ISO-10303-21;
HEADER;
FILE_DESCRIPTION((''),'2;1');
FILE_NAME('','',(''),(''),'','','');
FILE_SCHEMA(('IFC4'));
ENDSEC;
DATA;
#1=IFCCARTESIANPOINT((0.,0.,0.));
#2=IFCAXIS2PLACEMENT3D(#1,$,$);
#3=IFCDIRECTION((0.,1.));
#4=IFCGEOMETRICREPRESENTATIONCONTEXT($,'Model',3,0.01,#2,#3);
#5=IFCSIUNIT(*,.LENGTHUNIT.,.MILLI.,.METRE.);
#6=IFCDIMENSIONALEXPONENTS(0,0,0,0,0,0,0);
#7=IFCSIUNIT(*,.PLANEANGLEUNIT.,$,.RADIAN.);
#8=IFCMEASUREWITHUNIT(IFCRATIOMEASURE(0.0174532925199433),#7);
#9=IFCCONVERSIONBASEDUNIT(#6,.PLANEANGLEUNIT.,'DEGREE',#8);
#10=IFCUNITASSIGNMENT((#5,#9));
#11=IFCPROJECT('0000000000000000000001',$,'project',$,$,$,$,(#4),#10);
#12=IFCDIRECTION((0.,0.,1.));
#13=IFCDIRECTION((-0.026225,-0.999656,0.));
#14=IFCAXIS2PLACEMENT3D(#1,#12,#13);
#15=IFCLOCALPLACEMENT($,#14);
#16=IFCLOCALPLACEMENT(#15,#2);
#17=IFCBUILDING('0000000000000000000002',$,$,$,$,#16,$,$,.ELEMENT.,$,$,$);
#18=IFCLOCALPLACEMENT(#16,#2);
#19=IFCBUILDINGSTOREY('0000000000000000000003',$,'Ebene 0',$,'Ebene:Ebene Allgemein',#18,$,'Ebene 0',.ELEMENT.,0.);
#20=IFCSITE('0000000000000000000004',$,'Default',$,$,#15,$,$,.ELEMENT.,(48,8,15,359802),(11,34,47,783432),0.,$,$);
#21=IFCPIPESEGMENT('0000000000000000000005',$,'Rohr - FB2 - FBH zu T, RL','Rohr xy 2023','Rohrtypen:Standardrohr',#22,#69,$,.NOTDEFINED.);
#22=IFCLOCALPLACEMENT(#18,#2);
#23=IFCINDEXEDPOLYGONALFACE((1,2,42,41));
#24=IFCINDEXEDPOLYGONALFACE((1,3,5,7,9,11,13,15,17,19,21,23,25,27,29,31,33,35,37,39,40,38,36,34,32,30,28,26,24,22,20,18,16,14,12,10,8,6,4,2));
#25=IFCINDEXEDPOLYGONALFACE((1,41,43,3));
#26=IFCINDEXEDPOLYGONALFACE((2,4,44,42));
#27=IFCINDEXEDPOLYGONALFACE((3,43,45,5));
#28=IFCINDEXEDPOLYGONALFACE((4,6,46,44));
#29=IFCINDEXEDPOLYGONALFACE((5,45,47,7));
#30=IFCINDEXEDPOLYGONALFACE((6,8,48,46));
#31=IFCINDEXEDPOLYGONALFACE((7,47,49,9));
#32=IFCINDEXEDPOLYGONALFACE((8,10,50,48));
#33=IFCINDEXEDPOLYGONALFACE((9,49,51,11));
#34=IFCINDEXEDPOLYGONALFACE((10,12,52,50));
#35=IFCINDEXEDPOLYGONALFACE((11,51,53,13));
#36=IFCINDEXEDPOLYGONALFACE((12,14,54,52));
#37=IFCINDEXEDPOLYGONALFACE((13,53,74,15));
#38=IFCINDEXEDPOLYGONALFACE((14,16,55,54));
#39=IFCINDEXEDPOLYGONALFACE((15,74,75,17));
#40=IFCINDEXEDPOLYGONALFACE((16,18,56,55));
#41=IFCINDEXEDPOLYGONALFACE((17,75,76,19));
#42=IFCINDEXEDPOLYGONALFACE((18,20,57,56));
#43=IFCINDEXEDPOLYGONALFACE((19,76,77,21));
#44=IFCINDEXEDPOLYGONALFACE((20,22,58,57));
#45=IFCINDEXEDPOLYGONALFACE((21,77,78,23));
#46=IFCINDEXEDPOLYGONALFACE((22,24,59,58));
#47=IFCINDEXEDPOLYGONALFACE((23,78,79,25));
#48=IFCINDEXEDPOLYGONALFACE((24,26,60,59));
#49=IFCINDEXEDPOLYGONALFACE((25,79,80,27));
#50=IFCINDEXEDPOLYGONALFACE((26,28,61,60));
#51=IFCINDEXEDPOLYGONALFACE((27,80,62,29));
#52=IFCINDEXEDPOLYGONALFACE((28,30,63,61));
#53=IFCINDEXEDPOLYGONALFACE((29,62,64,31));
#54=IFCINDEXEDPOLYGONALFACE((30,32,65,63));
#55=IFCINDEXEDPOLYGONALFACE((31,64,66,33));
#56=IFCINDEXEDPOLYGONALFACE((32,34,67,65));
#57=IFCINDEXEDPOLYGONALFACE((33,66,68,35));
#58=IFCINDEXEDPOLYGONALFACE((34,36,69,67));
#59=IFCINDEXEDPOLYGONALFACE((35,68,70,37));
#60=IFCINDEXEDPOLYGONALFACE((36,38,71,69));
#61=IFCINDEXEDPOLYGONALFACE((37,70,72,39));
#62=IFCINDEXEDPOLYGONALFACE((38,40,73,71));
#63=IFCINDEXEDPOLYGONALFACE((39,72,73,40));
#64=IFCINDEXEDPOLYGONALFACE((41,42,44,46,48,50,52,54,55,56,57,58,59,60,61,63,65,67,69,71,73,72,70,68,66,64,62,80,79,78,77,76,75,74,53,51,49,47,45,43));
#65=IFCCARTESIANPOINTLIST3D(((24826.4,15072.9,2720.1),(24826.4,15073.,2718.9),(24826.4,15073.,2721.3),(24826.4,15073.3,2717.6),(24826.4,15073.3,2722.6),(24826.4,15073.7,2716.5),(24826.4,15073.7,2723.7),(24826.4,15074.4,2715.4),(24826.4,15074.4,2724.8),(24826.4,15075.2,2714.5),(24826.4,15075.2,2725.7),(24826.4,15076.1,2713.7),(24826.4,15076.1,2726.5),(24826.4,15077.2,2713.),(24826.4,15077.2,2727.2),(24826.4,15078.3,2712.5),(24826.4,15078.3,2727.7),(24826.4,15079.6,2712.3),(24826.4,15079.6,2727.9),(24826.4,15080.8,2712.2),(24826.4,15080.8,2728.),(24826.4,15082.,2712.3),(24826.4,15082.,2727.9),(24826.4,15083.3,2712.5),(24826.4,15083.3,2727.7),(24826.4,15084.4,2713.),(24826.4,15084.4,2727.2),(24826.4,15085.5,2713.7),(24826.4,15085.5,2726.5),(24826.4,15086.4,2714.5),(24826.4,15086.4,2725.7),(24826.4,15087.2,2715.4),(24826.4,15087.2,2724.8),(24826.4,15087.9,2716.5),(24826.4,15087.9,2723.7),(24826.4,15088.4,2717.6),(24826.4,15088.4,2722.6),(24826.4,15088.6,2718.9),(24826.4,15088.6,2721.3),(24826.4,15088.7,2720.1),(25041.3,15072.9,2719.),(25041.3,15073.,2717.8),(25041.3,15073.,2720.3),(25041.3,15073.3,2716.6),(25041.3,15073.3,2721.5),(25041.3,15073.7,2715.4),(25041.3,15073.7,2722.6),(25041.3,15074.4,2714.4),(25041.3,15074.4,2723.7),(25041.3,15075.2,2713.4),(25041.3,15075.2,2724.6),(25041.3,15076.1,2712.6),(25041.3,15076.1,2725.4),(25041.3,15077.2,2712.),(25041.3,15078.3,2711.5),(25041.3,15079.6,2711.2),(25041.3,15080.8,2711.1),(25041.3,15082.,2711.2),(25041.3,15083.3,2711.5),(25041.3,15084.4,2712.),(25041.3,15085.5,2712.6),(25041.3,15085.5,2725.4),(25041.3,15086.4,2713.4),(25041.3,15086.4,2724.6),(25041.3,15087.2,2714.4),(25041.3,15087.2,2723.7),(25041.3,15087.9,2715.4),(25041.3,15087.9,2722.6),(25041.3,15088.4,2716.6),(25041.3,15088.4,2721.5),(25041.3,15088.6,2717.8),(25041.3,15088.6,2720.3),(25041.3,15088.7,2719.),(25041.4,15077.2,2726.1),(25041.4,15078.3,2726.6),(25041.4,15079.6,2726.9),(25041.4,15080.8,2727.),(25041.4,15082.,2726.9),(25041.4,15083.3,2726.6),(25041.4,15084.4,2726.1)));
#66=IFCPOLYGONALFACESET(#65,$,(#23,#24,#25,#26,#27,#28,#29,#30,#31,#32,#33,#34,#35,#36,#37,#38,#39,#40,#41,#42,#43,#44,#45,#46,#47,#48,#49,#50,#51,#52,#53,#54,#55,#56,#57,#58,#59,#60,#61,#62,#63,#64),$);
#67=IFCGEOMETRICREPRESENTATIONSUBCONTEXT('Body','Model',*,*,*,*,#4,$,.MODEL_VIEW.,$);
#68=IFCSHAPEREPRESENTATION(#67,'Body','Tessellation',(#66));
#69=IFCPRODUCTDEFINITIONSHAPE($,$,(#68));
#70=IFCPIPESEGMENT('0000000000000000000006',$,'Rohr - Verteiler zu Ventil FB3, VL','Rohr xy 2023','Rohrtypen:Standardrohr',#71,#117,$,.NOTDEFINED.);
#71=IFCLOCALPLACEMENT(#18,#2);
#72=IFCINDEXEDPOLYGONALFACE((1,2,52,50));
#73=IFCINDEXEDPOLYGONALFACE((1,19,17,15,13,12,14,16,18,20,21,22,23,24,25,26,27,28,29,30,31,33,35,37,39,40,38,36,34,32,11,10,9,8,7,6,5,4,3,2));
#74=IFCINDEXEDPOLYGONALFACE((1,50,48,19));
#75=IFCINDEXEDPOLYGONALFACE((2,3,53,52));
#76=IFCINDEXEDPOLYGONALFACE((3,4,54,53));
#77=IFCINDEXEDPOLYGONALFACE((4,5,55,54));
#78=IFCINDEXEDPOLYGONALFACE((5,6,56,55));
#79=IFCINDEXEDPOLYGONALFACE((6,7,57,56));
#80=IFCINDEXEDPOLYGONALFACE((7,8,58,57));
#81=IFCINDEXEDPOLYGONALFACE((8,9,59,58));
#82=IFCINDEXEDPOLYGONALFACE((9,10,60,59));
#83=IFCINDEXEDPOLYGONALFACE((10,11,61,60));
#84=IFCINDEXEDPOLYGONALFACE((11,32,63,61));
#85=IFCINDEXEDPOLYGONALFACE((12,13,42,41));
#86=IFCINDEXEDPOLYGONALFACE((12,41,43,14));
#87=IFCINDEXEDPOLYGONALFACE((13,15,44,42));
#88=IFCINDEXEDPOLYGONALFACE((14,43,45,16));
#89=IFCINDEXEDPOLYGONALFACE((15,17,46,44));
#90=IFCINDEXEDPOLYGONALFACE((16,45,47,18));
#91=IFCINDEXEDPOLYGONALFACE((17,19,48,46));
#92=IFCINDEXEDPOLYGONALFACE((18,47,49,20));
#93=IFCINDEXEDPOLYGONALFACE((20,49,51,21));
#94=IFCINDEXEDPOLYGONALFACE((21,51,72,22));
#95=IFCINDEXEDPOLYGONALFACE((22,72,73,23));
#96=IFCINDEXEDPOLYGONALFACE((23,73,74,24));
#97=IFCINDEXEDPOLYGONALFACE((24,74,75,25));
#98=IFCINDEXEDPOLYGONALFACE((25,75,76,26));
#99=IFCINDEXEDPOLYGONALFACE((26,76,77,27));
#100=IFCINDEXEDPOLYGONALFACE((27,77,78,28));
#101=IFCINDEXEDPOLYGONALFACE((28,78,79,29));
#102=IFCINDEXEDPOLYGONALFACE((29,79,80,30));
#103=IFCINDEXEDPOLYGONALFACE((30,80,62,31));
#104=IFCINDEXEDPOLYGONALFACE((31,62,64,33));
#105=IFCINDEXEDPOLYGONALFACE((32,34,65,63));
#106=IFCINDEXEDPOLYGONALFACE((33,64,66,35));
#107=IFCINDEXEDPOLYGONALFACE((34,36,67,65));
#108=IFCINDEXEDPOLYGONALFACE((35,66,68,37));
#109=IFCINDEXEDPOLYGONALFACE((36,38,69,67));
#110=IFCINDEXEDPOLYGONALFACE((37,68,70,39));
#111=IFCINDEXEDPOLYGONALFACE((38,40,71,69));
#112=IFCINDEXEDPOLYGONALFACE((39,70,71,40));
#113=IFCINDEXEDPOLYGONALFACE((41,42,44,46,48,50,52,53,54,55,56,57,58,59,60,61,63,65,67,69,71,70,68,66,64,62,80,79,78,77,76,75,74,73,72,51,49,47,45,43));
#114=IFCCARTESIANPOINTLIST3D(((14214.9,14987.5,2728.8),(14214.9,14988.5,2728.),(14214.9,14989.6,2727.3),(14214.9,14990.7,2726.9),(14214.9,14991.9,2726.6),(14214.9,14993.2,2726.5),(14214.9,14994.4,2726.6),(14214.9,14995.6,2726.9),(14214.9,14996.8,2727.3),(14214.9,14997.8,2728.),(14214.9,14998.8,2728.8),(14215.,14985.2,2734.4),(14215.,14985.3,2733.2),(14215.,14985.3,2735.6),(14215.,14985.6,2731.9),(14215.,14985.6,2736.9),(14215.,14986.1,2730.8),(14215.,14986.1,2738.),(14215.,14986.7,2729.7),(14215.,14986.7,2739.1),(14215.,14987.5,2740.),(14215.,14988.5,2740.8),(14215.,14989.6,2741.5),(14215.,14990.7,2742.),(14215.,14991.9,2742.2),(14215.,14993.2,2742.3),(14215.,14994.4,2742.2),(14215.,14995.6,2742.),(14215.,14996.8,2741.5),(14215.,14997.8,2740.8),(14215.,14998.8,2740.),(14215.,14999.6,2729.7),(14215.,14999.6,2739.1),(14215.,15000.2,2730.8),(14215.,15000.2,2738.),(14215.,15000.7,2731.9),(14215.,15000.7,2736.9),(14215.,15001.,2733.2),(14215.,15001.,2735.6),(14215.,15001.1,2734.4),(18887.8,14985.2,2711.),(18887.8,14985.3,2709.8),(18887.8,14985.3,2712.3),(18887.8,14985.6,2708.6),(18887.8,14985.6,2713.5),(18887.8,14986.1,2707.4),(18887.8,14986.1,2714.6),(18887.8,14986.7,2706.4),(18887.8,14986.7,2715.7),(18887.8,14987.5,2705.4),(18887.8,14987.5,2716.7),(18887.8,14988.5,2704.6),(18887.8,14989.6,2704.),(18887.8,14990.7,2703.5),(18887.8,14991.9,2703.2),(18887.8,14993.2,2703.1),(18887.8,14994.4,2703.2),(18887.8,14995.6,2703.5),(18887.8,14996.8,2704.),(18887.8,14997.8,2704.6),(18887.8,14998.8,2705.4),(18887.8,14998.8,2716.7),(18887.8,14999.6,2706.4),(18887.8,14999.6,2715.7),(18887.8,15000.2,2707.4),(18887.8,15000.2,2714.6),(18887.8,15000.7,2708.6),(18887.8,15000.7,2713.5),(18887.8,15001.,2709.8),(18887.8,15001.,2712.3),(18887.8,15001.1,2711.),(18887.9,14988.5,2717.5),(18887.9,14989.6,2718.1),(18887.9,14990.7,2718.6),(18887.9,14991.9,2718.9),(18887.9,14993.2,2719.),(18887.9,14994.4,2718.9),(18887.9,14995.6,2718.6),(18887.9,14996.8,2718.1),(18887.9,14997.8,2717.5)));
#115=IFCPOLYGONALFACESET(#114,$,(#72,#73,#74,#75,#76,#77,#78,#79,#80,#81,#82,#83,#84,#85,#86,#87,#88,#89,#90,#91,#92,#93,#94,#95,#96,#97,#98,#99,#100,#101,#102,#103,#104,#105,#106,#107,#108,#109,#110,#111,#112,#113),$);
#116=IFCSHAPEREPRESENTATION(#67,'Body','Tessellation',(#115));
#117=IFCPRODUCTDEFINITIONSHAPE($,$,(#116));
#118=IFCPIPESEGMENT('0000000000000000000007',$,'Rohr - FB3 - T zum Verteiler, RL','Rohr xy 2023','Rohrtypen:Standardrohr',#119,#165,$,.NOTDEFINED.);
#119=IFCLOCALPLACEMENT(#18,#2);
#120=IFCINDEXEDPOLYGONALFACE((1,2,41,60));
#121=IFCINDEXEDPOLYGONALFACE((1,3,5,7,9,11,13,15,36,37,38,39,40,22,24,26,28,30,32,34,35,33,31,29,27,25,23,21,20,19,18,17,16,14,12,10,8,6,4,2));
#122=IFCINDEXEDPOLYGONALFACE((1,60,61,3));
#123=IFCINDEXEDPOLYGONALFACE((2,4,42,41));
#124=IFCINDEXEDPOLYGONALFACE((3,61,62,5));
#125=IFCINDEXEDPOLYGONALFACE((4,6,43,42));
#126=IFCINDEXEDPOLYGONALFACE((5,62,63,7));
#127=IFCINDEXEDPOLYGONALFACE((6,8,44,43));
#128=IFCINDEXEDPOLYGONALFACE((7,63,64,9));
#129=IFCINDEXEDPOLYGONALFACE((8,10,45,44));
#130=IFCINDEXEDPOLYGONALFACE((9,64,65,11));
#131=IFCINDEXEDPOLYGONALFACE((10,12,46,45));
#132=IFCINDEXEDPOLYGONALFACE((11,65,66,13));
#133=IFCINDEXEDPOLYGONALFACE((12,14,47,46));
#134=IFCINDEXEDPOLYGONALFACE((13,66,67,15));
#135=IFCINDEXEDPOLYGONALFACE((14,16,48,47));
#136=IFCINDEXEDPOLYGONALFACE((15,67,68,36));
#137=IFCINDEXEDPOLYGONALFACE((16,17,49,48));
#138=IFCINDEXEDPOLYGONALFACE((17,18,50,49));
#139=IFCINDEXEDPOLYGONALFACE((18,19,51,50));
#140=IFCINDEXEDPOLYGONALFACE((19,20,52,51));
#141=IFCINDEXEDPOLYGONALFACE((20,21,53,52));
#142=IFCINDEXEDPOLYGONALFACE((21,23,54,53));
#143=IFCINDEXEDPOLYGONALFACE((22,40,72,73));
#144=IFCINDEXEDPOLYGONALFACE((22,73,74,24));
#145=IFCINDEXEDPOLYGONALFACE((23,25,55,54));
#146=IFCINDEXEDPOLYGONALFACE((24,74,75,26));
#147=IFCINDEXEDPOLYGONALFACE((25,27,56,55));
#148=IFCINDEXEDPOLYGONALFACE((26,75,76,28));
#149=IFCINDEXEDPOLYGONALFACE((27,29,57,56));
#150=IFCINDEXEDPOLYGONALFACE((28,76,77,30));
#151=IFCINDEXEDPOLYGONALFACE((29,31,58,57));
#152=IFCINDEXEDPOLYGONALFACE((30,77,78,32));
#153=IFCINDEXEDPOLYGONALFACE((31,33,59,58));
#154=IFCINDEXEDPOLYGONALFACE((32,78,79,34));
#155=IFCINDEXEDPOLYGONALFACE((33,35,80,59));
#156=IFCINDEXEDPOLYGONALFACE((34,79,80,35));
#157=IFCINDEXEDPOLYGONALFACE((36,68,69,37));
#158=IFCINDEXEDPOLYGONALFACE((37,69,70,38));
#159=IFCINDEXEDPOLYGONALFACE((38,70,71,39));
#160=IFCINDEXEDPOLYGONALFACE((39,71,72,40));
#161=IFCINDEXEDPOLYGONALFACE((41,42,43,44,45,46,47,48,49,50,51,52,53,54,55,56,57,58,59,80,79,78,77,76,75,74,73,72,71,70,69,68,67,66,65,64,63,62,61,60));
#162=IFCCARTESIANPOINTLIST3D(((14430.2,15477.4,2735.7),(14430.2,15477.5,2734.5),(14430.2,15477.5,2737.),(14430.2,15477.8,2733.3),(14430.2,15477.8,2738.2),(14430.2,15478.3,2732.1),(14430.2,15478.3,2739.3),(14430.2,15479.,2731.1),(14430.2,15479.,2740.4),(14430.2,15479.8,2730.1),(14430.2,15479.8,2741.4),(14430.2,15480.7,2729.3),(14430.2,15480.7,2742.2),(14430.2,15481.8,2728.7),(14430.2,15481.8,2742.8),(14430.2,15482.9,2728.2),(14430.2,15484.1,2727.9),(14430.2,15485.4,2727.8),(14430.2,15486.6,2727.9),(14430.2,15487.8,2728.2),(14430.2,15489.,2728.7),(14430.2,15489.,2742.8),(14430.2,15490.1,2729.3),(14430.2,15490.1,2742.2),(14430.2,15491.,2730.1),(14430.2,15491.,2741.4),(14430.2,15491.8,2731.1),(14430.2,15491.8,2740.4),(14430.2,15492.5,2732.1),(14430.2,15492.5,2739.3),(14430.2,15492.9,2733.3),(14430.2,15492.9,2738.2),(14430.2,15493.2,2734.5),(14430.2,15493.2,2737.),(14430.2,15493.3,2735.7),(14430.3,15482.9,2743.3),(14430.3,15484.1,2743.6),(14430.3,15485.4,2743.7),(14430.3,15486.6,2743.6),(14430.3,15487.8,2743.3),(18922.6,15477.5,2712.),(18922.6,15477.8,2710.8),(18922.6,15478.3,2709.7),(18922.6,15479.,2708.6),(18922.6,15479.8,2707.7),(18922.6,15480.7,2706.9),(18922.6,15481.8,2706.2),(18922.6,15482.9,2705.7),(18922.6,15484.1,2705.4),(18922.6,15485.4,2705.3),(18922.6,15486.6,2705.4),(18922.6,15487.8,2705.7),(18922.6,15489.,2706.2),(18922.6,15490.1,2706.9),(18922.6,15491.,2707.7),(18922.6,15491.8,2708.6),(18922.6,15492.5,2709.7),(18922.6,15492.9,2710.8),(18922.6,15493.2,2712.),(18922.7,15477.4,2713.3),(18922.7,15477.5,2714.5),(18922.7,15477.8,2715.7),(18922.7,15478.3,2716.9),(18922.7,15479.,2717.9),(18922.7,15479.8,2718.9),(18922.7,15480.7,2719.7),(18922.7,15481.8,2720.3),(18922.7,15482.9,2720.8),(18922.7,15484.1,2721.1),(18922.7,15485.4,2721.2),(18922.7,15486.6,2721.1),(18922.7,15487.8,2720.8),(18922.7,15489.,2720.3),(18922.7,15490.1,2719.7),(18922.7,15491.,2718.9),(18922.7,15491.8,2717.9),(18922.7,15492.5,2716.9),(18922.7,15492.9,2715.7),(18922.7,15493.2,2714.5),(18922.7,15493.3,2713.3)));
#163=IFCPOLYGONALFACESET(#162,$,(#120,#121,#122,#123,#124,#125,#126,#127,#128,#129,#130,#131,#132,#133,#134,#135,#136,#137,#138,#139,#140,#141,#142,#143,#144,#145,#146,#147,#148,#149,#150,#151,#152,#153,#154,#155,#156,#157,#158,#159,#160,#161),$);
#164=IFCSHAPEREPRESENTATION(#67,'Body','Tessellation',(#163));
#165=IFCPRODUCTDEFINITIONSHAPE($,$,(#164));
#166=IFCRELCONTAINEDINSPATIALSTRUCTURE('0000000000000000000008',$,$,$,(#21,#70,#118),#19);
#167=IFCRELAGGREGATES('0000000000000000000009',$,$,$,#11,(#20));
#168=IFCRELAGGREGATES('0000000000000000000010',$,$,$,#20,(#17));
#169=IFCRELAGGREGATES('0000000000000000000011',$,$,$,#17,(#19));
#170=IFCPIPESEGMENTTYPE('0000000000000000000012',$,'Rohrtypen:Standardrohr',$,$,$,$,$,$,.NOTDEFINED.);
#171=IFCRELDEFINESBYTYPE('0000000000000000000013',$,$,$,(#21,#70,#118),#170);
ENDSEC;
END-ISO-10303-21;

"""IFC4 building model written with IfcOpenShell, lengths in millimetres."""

from ifc_helpers import new_model, entity, si_unit, converted_unit, direction, frame, origin, place, context, subcontext, project, spatial, indexed_curve, outline, extrude, type_object, element, save


model = new_model("IFC4")

# Units and contexts
model_context = context("Model", 3, precision=0.01, world=origin(), true_north=direction((0.0, 1.0)))
body_context = subcontext(model_context, "Body", "Model", "MODEL_VIEW")
ifc_project = project(units=[si_unit("LENGTHUNIT", "METRE", prefix="MILLI"), converted_unit("PLANEANGLEUNIT", "DEGREE", entity("IfcRatioMeasure", 0.0174532925199433), si_unit("PLANEANGLEUNIT", "RADIAN"), dimensions=[0, 0, 0, 0, 0, 0, 0])], contexts=[model_context])

# Site, building, storey
site_placement = place(None, frame((0.0, 0.0, 0.0), z_axis=(0.0, 0.0, 1.0), x_axis=(-0.026225, -0.999656, 0.0)))
site = spatial("IfcSite", under=ifc_project, at=site_placement, Name="Default", CompositionType="ELEMENT", RefLatitude=(48, 8, 15, 359802), RefLongitude=(11, 34, 47, 783432), RefElevation=0.0)
building_placement = place(site_placement, origin())
building = spatial("IfcBuilding", under=site, at=building_placement, CompositionType="ELEMENT")
storey_placement = place(building_placement, origin())
storey = spatial("IfcBuildingStorey", under=building, at=storey_placement, Name="Ebene 0", ObjectType="Ebene:Ebene Allgemein", LongName="Ebene 0", CompositionType="ELEMENT", Elevation=0.0)

# Pipe segments
pipe_segment_type = type_object("IfcPipeSegmentType", Name="Rohrtypen:Standardrohr", PredefinedType="NOTDEFINED")
pipe_segment_1_placement = place(storey_placement, origin())
element("IfcPipeSegment", 1, at=pipe_segment_1_placement, inside=storey, type_object=pipe_segment_type, Name="Rohr - FB2 - FBH zu T, RL", Description="Rohr xy 2023", ObjectType="Rohrtypen:Standardrohr", PredefinedType="NOTDEFINED", context=body_context, shape_type="SweptSolid", body=[
    extrude(outline(indexed_curve([(7.9, 0.0), (7.8, 1.2), (7.6, 2.5), (7.1, 3.6), (6.4, 4.7), (5.6, 5.6), (4.7, 6.4), (3.6, 7.1), (2.5, 7.6), (1.2, 7.8), (0.0, 7.9), (-1.2, 7.8), (-2.5, 7.6), (-3.6, 7.1), (-4.7, 6.4), (-5.6, 5.6), (-6.4, 4.7), (-7.1, 3.6), (-7.6, 2.5), (-7.8, 1.2), (-7.9, 0.0), (-7.8, -1.2), (-7.6, -2.5), (-7.1, -3.6), (-6.4, -4.7), (-5.6, -5.6), (-4.7, -6.4), (-3.6, -7.1), (-2.5, -7.6), (-1.2, -7.8), (0.0, -7.9), (1.2, -7.8), (2.5, -7.6), (3.6, -7.1), (4.7, -6.4), (5.6, -5.6), (6.4, -4.7), (7.1, -3.6), (7.6, -2.5), (7.8, -1.2), (7.9, 0.0)], self_intersect=False)), frame((25041.3, 15080.8, 2719.0), z_axis=(-0.999988, 0.0, 0.005), x_axis=(0.0, 1.0, 0.0)), (0.0, 0.0, 1.0), 214.9),
])
pipe_segment_2_placement = place(storey_placement, origin())
element("IfcPipeSegment", 2, at=pipe_segment_2_placement, inside=storey, type_object=pipe_segment_type, Name="Rohr - Verteiler zu Ventil FB3, VL", Description="Rohr xy 2023", ObjectType="Rohrtypen:Standardrohr", PredefinedType="NOTDEFINED", context=body_context, shape_type="SweptSolid", body=[
    extrude(outline(indexed_curve([(7.9, 0.0), (7.8, 1.2), (7.6, 2.5), (7.1, 3.6), (6.4, 4.7), (5.6, 5.6), (4.7, 6.4), (3.6, 7.1), (2.5, 7.6), (1.2, 7.8), (0.0, 7.9), (-1.2, 7.8), (-2.5, 7.6), (-3.6, 7.1), (-4.7, 6.4), (-5.6, 5.6), (-6.4, 4.7), (-7.1, 3.6), (-7.6, 2.5), (-7.8, 1.2), (-7.9, 0.0), (-7.8, -1.2), (-7.6, -2.5), (-7.1, -3.6), (-6.4, -4.7), (-5.6, -5.6), (-4.7, -6.4), (-3.6, -7.1), (-2.5, -7.6), (-1.2, -7.8), (0.0, -7.9), (1.2, -7.8), (2.5, -7.6), (3.6, -7.1), (4.7, -6.4), (5.6, -5.6), (6.4, -4.7), (7.1, -3.6), (7.6, -2.5), (7.8, -1.2), (7.9, 0.0)], self_intersect=False)), frame((18887.8, 14993.2, 2711.0), z_axis=(-0.999988, 0.0, 0.005), x_axis=(0.0, 1.0, 0.0)), (0.0, 0.0, 1.0), 4672.9),
])
pipe_segment_3_placement = place(storey_placement, origin())
element("IfcPipeSegment", 3, at=pipe_segment_3_placement, inside=storey, type_object=pipe_segment_type, Name="Rohr - FB3 - T zum Verteiler, RL", Description="Rohr xy 2023", ObjectType="Rohrtypen:Standardrohr", PredefinedType="NOTDEFINED", context=body_context, shape_type="SweptSolid", body=[
    extrude(outline(indexed_curve([(7.9, 0.0), (7.8, 1.2), (7.6, 2.5), (7.1, 3.6), (6.4, 4.7), (5.6, 5.6), (4.7, 6.4), (3.6, 7.1), (2.5, 7.6), (1.2, 7.8), (0.0, 7.9), (-1.2, 7.8), (-2.5, 7.6), (-3.6, 7.1), (-4.7, 6.4), (-5.6, 5.6), (-6.4, 4.7), (-7.1, 3.6), (-7.6, 2.5), (-7.8, 1.2), (-7.9, 0.0), (-7.8, -1.2), (-7.6, -2.5), (-7.1, -3.6), (-6.4, -4.7), (-5.6, -5.6), (-4.7, -6.4), (-3.6, -7.1), (-2.5, -7.6), (-1.2, -7.8), (0.0, -7.9), (1.2, -7.8), (2.5, -7.6), (3.6, -7.1), (4.7, -6.4), (5.6, -5.6), (6.4, -4.7), (7.1, -3.6), (7.6, -2.5), (7.8, -1.2), (7.9, 0.0)], self_intersect=False)), frame((14430.2, 15485.4, 2735.7), z_axis=(0.999988, 0.0, -0.005), x_axis=(0.0, 1.0, 0.0)), (0.0, 0.0, 1.0), 4492.5),
])

save(model, "model.ifc")
